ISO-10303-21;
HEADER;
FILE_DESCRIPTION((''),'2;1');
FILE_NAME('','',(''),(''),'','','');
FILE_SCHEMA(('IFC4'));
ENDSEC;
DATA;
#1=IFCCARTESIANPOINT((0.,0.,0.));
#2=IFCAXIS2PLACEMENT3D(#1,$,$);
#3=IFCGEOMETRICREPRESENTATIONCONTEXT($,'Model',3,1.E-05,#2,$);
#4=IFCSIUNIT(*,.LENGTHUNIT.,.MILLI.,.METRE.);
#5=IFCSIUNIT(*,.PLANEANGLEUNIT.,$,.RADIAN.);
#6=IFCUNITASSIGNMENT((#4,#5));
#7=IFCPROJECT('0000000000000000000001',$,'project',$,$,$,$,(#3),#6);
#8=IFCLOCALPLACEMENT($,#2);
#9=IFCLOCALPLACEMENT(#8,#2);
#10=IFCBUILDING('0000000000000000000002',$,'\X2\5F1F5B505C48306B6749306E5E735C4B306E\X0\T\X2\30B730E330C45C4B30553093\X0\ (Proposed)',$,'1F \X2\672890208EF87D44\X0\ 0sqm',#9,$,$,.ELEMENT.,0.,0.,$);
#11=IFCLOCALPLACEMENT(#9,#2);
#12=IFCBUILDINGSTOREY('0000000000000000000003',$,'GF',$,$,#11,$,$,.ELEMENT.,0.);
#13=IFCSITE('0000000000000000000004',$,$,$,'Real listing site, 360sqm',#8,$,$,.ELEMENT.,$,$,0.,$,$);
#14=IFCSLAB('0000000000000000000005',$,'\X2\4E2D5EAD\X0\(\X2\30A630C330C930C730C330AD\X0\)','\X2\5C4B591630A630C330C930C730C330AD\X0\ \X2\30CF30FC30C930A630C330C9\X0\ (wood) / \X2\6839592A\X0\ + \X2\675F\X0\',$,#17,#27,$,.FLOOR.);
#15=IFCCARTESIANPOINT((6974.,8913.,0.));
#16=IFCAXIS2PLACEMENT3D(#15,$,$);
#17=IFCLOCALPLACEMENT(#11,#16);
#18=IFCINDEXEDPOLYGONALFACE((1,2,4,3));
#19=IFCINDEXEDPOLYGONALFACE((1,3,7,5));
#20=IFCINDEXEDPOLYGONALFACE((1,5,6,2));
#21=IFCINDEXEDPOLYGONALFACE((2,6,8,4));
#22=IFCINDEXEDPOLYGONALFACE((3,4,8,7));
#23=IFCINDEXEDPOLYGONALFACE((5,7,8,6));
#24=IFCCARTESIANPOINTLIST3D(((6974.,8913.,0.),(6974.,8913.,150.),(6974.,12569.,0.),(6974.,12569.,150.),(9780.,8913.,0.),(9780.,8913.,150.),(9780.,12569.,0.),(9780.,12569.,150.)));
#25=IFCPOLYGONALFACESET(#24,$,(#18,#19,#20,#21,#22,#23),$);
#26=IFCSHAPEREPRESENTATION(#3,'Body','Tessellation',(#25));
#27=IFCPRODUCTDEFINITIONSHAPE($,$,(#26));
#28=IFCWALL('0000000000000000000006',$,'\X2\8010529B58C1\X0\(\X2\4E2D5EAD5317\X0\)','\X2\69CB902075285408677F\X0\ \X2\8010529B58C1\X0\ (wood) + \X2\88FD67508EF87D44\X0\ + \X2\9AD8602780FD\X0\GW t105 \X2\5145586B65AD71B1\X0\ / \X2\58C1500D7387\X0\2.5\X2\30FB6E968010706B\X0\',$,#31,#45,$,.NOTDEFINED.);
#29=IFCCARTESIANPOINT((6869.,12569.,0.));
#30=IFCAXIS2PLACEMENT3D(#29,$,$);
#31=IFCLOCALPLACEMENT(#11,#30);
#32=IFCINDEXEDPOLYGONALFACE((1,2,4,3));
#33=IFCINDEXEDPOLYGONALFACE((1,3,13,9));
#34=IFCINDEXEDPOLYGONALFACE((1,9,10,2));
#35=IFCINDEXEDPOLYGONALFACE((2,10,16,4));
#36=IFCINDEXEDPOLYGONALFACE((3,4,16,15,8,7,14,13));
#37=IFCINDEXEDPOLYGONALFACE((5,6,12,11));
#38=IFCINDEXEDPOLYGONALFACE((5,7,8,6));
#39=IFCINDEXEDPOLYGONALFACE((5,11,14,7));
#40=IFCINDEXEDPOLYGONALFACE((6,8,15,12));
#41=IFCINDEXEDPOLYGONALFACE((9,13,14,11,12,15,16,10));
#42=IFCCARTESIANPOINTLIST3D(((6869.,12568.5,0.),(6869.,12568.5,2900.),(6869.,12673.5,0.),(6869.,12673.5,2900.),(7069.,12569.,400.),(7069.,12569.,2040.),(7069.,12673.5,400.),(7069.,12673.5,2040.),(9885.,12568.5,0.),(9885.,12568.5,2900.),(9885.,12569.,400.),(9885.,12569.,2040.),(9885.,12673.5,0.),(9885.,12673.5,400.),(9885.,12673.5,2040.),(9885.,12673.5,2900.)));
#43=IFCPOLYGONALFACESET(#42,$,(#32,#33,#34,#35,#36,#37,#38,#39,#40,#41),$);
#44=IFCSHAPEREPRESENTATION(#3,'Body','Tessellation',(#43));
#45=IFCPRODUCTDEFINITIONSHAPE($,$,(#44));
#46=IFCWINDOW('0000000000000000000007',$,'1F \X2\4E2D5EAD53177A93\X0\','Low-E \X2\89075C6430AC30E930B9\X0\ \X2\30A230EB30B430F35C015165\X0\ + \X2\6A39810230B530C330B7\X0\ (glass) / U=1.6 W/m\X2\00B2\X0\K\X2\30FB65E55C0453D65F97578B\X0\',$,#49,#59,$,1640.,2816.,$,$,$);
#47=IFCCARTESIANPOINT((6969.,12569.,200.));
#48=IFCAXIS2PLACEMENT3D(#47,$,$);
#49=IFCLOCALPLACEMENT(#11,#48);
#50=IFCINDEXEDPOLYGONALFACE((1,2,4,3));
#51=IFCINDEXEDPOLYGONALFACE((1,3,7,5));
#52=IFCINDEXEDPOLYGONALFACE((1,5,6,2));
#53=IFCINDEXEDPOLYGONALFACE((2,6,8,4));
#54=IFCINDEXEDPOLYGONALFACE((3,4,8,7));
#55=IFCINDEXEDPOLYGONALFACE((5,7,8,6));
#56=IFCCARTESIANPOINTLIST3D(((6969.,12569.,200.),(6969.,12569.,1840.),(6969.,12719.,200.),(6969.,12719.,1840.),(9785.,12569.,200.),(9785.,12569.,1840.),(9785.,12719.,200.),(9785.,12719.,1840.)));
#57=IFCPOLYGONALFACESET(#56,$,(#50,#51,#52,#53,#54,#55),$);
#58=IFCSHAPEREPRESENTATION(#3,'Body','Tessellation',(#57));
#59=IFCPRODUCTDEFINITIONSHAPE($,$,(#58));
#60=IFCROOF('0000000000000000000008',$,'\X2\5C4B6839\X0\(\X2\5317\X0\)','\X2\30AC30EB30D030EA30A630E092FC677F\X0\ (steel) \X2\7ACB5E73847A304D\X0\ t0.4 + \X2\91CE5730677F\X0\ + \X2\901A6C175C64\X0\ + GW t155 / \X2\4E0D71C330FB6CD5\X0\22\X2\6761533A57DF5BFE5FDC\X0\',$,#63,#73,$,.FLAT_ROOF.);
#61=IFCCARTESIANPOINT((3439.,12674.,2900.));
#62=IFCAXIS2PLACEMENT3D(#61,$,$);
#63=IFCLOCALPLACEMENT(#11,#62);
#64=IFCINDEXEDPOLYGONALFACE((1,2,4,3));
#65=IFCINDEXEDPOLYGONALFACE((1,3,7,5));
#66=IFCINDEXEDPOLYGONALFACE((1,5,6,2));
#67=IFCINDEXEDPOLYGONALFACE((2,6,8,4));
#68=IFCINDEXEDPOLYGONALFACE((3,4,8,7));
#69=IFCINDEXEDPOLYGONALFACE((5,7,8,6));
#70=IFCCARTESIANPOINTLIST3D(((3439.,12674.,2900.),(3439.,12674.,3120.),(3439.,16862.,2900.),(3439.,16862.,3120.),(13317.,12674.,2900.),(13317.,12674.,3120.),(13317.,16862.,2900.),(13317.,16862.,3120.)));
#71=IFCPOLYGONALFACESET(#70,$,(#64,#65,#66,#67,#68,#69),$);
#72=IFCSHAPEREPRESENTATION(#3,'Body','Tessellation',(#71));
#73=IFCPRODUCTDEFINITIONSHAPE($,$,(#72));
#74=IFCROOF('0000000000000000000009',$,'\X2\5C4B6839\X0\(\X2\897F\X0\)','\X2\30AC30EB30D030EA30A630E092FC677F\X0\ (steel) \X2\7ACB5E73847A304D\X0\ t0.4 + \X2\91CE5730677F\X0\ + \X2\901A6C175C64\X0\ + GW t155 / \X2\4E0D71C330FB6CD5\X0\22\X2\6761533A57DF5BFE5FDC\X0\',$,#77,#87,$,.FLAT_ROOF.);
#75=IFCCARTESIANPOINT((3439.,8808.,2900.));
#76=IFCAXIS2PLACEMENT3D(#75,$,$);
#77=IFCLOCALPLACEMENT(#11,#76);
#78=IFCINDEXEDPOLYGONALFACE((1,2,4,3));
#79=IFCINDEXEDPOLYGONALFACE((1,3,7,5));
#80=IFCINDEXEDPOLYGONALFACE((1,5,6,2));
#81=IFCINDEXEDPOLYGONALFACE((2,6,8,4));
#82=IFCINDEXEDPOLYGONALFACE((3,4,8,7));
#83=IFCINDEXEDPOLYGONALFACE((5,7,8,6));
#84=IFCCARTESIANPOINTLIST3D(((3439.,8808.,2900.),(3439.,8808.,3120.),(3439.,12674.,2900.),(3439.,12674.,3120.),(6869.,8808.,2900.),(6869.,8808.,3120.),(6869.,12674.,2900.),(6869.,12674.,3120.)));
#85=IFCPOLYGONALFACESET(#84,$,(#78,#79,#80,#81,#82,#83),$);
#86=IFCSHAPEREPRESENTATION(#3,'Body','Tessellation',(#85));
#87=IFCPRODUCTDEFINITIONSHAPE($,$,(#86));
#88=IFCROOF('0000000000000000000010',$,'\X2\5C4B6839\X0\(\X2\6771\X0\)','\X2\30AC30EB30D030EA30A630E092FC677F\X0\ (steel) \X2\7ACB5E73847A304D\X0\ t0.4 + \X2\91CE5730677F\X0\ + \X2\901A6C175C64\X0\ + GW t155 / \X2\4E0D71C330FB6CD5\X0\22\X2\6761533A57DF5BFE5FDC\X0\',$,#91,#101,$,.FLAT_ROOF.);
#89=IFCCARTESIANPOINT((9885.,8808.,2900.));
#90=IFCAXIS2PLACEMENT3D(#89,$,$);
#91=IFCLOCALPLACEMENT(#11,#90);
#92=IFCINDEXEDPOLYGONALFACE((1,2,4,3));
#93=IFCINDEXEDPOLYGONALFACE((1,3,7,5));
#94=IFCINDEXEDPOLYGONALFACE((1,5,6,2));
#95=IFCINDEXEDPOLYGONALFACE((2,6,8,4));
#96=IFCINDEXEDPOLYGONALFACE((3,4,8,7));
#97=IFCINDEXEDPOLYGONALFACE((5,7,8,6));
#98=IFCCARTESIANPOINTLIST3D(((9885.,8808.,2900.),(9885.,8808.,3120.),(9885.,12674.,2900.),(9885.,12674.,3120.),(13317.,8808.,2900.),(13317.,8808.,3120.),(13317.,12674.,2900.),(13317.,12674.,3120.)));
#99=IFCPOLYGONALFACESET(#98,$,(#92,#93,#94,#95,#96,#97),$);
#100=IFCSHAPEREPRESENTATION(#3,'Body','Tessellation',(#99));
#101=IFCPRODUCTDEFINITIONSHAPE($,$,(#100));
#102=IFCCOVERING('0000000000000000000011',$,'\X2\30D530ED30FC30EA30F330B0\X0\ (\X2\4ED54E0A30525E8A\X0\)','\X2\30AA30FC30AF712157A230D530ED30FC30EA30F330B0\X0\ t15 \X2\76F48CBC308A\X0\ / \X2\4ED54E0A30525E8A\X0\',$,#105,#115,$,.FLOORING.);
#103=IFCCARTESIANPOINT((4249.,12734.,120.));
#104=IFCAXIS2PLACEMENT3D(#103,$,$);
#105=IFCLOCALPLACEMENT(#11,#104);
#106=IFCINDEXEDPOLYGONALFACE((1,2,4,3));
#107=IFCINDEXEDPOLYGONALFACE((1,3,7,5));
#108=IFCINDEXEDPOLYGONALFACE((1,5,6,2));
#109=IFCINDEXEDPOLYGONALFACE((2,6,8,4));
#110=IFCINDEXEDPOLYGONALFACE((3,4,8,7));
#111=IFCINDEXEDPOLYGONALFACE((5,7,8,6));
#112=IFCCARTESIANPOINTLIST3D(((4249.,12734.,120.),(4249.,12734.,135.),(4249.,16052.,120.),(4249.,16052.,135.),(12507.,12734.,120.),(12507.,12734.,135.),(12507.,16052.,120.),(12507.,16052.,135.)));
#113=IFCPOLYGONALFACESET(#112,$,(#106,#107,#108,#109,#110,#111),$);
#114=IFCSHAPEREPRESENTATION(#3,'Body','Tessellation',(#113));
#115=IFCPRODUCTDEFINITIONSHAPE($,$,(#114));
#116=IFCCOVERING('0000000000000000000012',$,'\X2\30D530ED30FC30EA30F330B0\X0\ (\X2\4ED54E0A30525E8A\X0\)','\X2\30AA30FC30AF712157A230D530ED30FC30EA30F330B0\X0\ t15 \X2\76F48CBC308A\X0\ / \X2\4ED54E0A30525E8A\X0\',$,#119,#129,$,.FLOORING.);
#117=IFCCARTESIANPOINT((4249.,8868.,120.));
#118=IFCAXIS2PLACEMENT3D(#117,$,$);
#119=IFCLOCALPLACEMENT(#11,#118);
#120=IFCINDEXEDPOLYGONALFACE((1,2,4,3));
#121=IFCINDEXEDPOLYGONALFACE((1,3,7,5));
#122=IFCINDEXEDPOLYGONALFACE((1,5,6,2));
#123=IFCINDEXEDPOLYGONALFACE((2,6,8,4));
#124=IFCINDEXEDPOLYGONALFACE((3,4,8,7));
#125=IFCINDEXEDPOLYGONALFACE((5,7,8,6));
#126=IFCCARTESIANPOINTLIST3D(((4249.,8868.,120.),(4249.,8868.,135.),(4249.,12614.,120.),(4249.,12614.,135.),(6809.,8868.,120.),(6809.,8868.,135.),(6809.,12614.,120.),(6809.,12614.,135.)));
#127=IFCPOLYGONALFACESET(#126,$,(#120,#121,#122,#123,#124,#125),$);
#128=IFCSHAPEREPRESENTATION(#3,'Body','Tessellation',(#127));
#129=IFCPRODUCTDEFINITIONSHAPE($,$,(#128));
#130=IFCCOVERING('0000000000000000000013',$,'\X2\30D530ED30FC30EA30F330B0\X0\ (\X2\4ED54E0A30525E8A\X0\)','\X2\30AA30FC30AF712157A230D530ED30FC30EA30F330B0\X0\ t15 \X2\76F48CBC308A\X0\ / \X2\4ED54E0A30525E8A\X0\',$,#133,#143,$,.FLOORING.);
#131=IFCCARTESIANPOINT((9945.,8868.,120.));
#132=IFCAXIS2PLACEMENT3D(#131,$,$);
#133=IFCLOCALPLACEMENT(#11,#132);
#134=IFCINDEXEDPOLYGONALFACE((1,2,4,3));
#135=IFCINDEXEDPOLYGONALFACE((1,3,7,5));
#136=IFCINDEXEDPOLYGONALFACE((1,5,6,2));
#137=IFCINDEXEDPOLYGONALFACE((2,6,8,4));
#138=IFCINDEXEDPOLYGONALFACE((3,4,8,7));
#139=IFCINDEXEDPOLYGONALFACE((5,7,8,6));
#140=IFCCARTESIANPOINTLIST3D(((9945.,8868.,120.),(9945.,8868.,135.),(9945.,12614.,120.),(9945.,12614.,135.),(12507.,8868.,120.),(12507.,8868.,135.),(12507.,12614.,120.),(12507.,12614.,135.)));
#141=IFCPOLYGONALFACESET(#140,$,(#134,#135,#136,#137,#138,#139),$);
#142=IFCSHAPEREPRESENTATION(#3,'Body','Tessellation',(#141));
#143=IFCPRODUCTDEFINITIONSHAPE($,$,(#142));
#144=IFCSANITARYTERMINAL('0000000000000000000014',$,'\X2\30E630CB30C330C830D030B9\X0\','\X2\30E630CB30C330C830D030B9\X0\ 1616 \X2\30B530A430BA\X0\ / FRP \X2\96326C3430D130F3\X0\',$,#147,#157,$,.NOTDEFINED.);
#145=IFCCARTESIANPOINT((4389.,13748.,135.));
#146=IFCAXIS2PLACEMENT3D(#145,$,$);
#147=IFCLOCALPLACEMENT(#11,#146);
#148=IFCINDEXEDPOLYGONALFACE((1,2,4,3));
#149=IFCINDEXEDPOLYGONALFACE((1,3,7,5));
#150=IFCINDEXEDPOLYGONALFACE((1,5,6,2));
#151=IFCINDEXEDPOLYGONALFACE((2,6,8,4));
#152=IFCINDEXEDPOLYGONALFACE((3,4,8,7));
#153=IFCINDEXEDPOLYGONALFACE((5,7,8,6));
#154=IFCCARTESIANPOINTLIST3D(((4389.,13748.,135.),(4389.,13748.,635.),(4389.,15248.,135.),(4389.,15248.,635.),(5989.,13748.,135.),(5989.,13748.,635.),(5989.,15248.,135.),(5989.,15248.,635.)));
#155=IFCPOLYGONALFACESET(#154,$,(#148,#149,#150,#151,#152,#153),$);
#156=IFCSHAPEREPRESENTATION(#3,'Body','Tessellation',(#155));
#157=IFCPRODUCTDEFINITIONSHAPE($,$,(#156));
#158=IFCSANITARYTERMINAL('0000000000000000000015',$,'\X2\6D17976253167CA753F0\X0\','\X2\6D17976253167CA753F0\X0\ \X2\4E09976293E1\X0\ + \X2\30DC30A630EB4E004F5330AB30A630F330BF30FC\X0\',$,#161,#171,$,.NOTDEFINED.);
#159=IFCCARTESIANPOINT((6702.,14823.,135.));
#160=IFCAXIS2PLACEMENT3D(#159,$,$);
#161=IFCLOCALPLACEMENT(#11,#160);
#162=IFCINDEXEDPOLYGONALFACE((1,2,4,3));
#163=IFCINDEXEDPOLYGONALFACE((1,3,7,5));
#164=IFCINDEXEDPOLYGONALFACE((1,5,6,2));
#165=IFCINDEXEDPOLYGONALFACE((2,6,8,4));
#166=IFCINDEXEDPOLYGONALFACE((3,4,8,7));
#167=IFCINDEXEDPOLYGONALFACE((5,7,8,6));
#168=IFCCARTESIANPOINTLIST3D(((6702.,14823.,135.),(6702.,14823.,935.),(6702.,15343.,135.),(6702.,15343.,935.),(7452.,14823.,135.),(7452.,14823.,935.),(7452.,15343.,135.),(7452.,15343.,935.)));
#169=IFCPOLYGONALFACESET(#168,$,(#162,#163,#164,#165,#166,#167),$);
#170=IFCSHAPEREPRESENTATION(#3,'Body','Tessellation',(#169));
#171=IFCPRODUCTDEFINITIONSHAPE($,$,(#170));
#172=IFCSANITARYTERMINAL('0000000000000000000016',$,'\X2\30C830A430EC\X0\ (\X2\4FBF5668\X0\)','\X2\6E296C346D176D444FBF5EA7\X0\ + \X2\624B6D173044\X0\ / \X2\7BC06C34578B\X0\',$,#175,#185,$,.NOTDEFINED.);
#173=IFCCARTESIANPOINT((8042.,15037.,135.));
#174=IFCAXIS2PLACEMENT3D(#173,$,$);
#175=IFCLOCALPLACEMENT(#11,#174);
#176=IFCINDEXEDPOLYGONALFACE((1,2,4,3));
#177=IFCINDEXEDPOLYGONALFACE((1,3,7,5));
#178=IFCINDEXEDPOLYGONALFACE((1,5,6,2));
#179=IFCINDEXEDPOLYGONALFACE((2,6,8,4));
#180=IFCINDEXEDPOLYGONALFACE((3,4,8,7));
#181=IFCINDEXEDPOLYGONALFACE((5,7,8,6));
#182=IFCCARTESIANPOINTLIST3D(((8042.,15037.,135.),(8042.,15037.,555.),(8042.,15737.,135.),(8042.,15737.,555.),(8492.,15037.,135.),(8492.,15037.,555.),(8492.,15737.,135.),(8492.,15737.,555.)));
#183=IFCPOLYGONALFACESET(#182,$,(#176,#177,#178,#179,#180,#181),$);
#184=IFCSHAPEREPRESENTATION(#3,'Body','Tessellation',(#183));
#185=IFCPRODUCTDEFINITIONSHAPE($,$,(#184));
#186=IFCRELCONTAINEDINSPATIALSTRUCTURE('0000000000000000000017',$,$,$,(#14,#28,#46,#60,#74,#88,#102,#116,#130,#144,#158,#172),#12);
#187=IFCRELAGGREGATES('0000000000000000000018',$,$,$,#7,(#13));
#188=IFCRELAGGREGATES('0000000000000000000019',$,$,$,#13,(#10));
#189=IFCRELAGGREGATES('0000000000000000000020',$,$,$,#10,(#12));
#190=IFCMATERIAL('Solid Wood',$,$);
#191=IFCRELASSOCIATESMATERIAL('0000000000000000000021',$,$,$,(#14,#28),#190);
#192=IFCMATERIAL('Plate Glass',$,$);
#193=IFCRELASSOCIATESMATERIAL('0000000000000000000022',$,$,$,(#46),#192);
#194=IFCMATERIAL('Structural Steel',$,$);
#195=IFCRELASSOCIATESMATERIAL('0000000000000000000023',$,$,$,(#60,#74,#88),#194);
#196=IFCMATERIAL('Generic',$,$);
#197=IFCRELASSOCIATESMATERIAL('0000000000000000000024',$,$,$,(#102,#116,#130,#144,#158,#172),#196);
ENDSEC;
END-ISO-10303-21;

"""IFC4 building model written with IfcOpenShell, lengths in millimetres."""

from ifc_helpers import new_model, si_unit, frame, frame_2d, origin, place, context, project, spatial, rectangle, extrude, material, element, fill, save


model = new_model("IFC4")

# Units and contexts
model_context = context("Model", 3, precision=1e-05, world=origin())
ifc_project = project(units=[si_unit("LENGTHUNIT", "METRE", prefix="MILLI"), si_unit("PLANEANGLEUNIT", "RADIAN")], contexts=[model_context])

# Site, building, storey
site_placement = place(None, origin())
site = spatial("IfcSite", under=ifc_project, at=site_placement, ObjectType="Real listing site, 360sqm", CompositionType="ELEMENT", RefElevation=0.0)
building_placement = place(site_placement, origin())
building = spatial("IfcBuilding", under=site, at=building_placement, Name="弟子屈に杉の平屋のTシャツ屋さん (Proposed)", ObjectType="1F 木造軸組 0sqm", CompositionType="ELEMENT", ElevationOfRefHeight=0.0, ElevationOfTerrain=0.0)
storey_placement = place(building_placement, origin())
storey = spatial("IfcBuildingStorey", under=building, at=storey_placement, Name="GF", CompositionType="ELEMENT", Elevation=0.0)

# Slab
ifc_material_1 = material(Name="Solid Wood")
slab_1_placement = place(storey_placement, frame((6974.0, 8913.0, 0.0)))
element("IfcSlab", 1, at=slab_1_placement, inside=storey, material=ifc_material_1, Name="中庭(ウッドデッキ)", Description="屋外ウッドデッキ ハードウッド (wood) / 根太 + 束", PredefinedType="FLOOR", context=model_context, shape_type="SweptSolid", body=[
    extrude(rectangle(XDim=2806.0, YDim=3656.0, at=frame_2d((1403.0, 1828.0))), frame((6974.0, 8913.0, 0.0)), (0.0, 0.0, 1.0), 150.0),
])

# Wall, opening, window
wall_1_placement = place(storey_placement, frame((6869.0, 12569.0, 0.0)))
wall_1 = element("IfcWall", 2, at=wall_1_placement, inside=storey, material=ifc_material_1, Name="耐力壁(中庭北)", Description="構造用合板 耐力壁 (wood) + 製材軸組 + 高性能GW t105 充填断熱 / 壁倍率2.5・準耐火", PredefinedType="NOTDEFINED", context=model_context, shape_type="SweptSolid", body=[
    extrude(rectangle(XDim=3016.0, YDim=105.0, at=frame_2d((1508.0, 52.0))), frame((6869.0, 12569.0, 0.0)), (0.0, 0.0, 1.0), 2900.0),
])
opening_placement = place(storey_placement, frame((6969.0, 12569.0, 200.0)))
opening = element("IfcOpeningElement", 3, at=opening_placement, cuts=wall_1, PredefinedType="NOTDEFINED", context=model_context, shape_type="SweptSolid", body=[
    extrude(rectangle(XDim=2816.0, YDim=150.0, at=frame_2d((1408.0, 75.0))), frame((6969.0, 12569.0, 200.0)), (0.0, 0.0, 1.0), 1640.0),
])
ifc_material_2 = material(Name="Plate Glass")
window_placement = place(storey_placement, frame((6969.0, 12569.0, 200.0)))
window = element("IfcWindow", 4, at=window_placement, inside=storey, material=ifc_material_2, Name="1F 中庭北窓", Description="Low-E 複層ガラス アルゴン封入 + 樹脂サッシ (glass) / U=1.6 W/m²K・日射取得型", OverallHeight=1640.0, OverallWidth=2816.0, context=model_context, shape_type="SweptSolid", body=[
    extrude(rectangle(XDim=2816.0, YDim=150.0, at=frame_2d((1408.0, 75.0))), frame((6969.0, 12569.0, 200.0)), (0.0, 0.0, 1.0), 1640.0),
])
fill(opening, window)

# Roofs
ifc_material_3 = material(Name="Structural Steel")
roof_1_placement = place(storey_placement, frame((3439.0, 12674.0, 2900.0)))
element("IfcRoof", 5, at=roof_1_placement, inside=storey, material=ifc_material_3, Name="屋根(北)", Description="ガルバリウム鋼板 (steel) 立平葺き t0.4 + 野地板 + 通気層 + GW t155 / 不燃・法22条区域対応", PredefinedType="FLAT_ROOF", context=model_context, shape_type="SweptSolid", body=[
    extrude(rectangle(XDim=9878.0, YDim=4188.0, at=frame_2d((4939.0, 2094.0))), frame((3439.0, 12674.0, 2900.0)), (0.0, 0.0, 1.0), 220.0),
])
roof_2_placement = place(storey_placement, frame((3439.0, 8808.0, 2900.0)))
element("IfcRoof", 6, at=roof_2_placement, inside=storey, material=ifc_material_3, Name="屋根(西)", Description="ガルバリウム鋼板 (steel) 立平葺き t0.4 + 野地板 + 通気層 + GW t155 / 不燃・法22条区域対応", PredefinedType="FLAT_ROOF", context=model_context, shape_type="SweptSolid", body=[
    extrude(rectangle(XDim=3430.0, YDim=3866.0, at=frame_2d((1715.0, 1933.0))), frame((3439.0, 8808.0, 2900.0)), (0.0, 0.0, 1.0), 220.0),
])
roof_3_placement = place(storey_placement, frame((9885.0, 8808.0, 2900.0)))
element("IfcRoof", 7, at=roof_3_placement, inside=storey, material=ifc_material_3, Name="屋根(東)", Description="ガルバリウム鋼板 (steel) 立平葺き t0.4 + 野地板 + 通気層 + GW t155 / 不燃・法22条区域対応", PredefinedType="FLAT_ROOF", context=model_context, shape_type="SweptSolid", body=[
    extrude(rectangle(XDim=3432.0, YDim=3866.0, at=frame_2d((1716.0, 1933.0))), frame((9885.0, 8808.0, 2900.0)), (0.0, 0.0, 1.0), 220.0),
])

# Coverings
ifc_material_4 = material(Name="Generic")
covering_1_placement = place(storey_placement, frame((4249.0, 12734.0, 120.0)))
element("IfcCovering", 8, at=covering_1_placement, inside=storey, material=ifc_material_4, Name="フローリング (仕上げ床)", Description="オーク無垢フローリング t15 直貼り / 仕上げ床", PredefinedType="FLOORING", context=model_context, shape_type="SweptSolid", body=[
    extrude(rectangle(XDim=8258.0, YDim=3318.0, at=frame_2d((4129.0, 1659.0))), frame((4249.0, 12734.0, 120.0)), (0.0, 0.0, 1.0), 15.0),
])
covering_2_placement = place(storey_placement, frame((4249.0, 8868.0, 120.0)))
element("IfcCovering", 9, at=covering_2_placement, inside=storey, material=ifc_material_4, Name="フローリング (仕上げ床)", Description="オーク無垢フローリング t15 直貼り / 仕上げ床", PredefinedType="FLOORING", context=model_context, shape_type="SweptSolid", body=[
    extrude(rectangle(XDim=2560.0, YDim=3746.0, at=frame_2d((1280.0, 1873.0))), frame((4249.0, 8868.0, 120.0)), (0.0, 0.0, 1.0), 15.0),
])
covering_3_placement = place(storey_placement, frame((9945.0, 8868.0, 120.0)))
element("IfcCovering", 10, at=covering_3_placement, inside=storey, material=ifc_material_4, Name="フローリング (仕上げ床)", Description="オーク無垢フローリング t15 直貼り / 仕上げ床", PredefinedType="FLOORING", context=model_context, shape_type="SweptSolid", body=[
    extrude(rectangle(XDim=2562.0, YDim=3746.0, at=frame_2d((1281.0, 1873.0))), frame((9945.0, 8868.0, 120.0)), (0.0, 0.0, 1.0), 15.0),
])

# Sanitary terminals
sanitary_terminal_1_placement = place(storey_placement, frame((4389.0, 13748.0, 135.0)))
element("IfcSanitaryTerminal", 11, at=sanitary_terminal_1_placement, inside=storey, material=ifc_material_4, Name="ユニットバス", Description="ユニットバス 1616 サイズ / FRP 防水パン", PredefinedType="NOTDEFINED", context=model_context, shape_type="SweptSolid", body=[
    extrude(rectangle(XDim=1600.0, YDim=1500.0, at=frame_2d((800.0, 750.0))), frame((4389.0, 13748.0, 135.0)), (0.0, 0.0, 1.0), 500.0),
])
sanitary_terminal_2_placement = place(storey_placement, frame((6702.0, 14823.0, 135.0)))
element("IfcSanitaryTerminal", 12, at=sanitary_terminal_2_placement, inside=storey, material=ifc_material_4, Name="洗面化粧台", Description="洗面化粧台 三面鏡 + ボウル一体カウンター", PredefinedType="NOTDEFINED", context=model_context, shape_type="SweptSolid", body=[
    extrude(rectangle(XDim=750.0, YDim=520.0, at=frame_2d((375.0, 260.0))), frame((6702.0, 14823.0, 135.0)), (0.0, 0.0, 1.0), 800.0),
])
sanitary_terminal_3_placement = place(storey_placement, frame((8042.0, 15037.0, 135.0)))
element("IfcSanitaryTerminal", 13, at=sanitary_terminal_3_placement, inside=storey, material=ifc_material_4, Name="トイレ (便器)", Description="温水洗浄便座 + 手洗い / 節水型", PredefinedType="NOTDEFINED", context=model_context, shape_type="SweptSolid", body=[
    extrude(rectangle(XDim=450.0, YDim=700.0, at=frame_2d((225.0, 350.0))), frame((8042.0, 15037.0, 135.0)), (0.0, 0.0, 1.0), 420.0),
])

save(model, "model.ifc")
